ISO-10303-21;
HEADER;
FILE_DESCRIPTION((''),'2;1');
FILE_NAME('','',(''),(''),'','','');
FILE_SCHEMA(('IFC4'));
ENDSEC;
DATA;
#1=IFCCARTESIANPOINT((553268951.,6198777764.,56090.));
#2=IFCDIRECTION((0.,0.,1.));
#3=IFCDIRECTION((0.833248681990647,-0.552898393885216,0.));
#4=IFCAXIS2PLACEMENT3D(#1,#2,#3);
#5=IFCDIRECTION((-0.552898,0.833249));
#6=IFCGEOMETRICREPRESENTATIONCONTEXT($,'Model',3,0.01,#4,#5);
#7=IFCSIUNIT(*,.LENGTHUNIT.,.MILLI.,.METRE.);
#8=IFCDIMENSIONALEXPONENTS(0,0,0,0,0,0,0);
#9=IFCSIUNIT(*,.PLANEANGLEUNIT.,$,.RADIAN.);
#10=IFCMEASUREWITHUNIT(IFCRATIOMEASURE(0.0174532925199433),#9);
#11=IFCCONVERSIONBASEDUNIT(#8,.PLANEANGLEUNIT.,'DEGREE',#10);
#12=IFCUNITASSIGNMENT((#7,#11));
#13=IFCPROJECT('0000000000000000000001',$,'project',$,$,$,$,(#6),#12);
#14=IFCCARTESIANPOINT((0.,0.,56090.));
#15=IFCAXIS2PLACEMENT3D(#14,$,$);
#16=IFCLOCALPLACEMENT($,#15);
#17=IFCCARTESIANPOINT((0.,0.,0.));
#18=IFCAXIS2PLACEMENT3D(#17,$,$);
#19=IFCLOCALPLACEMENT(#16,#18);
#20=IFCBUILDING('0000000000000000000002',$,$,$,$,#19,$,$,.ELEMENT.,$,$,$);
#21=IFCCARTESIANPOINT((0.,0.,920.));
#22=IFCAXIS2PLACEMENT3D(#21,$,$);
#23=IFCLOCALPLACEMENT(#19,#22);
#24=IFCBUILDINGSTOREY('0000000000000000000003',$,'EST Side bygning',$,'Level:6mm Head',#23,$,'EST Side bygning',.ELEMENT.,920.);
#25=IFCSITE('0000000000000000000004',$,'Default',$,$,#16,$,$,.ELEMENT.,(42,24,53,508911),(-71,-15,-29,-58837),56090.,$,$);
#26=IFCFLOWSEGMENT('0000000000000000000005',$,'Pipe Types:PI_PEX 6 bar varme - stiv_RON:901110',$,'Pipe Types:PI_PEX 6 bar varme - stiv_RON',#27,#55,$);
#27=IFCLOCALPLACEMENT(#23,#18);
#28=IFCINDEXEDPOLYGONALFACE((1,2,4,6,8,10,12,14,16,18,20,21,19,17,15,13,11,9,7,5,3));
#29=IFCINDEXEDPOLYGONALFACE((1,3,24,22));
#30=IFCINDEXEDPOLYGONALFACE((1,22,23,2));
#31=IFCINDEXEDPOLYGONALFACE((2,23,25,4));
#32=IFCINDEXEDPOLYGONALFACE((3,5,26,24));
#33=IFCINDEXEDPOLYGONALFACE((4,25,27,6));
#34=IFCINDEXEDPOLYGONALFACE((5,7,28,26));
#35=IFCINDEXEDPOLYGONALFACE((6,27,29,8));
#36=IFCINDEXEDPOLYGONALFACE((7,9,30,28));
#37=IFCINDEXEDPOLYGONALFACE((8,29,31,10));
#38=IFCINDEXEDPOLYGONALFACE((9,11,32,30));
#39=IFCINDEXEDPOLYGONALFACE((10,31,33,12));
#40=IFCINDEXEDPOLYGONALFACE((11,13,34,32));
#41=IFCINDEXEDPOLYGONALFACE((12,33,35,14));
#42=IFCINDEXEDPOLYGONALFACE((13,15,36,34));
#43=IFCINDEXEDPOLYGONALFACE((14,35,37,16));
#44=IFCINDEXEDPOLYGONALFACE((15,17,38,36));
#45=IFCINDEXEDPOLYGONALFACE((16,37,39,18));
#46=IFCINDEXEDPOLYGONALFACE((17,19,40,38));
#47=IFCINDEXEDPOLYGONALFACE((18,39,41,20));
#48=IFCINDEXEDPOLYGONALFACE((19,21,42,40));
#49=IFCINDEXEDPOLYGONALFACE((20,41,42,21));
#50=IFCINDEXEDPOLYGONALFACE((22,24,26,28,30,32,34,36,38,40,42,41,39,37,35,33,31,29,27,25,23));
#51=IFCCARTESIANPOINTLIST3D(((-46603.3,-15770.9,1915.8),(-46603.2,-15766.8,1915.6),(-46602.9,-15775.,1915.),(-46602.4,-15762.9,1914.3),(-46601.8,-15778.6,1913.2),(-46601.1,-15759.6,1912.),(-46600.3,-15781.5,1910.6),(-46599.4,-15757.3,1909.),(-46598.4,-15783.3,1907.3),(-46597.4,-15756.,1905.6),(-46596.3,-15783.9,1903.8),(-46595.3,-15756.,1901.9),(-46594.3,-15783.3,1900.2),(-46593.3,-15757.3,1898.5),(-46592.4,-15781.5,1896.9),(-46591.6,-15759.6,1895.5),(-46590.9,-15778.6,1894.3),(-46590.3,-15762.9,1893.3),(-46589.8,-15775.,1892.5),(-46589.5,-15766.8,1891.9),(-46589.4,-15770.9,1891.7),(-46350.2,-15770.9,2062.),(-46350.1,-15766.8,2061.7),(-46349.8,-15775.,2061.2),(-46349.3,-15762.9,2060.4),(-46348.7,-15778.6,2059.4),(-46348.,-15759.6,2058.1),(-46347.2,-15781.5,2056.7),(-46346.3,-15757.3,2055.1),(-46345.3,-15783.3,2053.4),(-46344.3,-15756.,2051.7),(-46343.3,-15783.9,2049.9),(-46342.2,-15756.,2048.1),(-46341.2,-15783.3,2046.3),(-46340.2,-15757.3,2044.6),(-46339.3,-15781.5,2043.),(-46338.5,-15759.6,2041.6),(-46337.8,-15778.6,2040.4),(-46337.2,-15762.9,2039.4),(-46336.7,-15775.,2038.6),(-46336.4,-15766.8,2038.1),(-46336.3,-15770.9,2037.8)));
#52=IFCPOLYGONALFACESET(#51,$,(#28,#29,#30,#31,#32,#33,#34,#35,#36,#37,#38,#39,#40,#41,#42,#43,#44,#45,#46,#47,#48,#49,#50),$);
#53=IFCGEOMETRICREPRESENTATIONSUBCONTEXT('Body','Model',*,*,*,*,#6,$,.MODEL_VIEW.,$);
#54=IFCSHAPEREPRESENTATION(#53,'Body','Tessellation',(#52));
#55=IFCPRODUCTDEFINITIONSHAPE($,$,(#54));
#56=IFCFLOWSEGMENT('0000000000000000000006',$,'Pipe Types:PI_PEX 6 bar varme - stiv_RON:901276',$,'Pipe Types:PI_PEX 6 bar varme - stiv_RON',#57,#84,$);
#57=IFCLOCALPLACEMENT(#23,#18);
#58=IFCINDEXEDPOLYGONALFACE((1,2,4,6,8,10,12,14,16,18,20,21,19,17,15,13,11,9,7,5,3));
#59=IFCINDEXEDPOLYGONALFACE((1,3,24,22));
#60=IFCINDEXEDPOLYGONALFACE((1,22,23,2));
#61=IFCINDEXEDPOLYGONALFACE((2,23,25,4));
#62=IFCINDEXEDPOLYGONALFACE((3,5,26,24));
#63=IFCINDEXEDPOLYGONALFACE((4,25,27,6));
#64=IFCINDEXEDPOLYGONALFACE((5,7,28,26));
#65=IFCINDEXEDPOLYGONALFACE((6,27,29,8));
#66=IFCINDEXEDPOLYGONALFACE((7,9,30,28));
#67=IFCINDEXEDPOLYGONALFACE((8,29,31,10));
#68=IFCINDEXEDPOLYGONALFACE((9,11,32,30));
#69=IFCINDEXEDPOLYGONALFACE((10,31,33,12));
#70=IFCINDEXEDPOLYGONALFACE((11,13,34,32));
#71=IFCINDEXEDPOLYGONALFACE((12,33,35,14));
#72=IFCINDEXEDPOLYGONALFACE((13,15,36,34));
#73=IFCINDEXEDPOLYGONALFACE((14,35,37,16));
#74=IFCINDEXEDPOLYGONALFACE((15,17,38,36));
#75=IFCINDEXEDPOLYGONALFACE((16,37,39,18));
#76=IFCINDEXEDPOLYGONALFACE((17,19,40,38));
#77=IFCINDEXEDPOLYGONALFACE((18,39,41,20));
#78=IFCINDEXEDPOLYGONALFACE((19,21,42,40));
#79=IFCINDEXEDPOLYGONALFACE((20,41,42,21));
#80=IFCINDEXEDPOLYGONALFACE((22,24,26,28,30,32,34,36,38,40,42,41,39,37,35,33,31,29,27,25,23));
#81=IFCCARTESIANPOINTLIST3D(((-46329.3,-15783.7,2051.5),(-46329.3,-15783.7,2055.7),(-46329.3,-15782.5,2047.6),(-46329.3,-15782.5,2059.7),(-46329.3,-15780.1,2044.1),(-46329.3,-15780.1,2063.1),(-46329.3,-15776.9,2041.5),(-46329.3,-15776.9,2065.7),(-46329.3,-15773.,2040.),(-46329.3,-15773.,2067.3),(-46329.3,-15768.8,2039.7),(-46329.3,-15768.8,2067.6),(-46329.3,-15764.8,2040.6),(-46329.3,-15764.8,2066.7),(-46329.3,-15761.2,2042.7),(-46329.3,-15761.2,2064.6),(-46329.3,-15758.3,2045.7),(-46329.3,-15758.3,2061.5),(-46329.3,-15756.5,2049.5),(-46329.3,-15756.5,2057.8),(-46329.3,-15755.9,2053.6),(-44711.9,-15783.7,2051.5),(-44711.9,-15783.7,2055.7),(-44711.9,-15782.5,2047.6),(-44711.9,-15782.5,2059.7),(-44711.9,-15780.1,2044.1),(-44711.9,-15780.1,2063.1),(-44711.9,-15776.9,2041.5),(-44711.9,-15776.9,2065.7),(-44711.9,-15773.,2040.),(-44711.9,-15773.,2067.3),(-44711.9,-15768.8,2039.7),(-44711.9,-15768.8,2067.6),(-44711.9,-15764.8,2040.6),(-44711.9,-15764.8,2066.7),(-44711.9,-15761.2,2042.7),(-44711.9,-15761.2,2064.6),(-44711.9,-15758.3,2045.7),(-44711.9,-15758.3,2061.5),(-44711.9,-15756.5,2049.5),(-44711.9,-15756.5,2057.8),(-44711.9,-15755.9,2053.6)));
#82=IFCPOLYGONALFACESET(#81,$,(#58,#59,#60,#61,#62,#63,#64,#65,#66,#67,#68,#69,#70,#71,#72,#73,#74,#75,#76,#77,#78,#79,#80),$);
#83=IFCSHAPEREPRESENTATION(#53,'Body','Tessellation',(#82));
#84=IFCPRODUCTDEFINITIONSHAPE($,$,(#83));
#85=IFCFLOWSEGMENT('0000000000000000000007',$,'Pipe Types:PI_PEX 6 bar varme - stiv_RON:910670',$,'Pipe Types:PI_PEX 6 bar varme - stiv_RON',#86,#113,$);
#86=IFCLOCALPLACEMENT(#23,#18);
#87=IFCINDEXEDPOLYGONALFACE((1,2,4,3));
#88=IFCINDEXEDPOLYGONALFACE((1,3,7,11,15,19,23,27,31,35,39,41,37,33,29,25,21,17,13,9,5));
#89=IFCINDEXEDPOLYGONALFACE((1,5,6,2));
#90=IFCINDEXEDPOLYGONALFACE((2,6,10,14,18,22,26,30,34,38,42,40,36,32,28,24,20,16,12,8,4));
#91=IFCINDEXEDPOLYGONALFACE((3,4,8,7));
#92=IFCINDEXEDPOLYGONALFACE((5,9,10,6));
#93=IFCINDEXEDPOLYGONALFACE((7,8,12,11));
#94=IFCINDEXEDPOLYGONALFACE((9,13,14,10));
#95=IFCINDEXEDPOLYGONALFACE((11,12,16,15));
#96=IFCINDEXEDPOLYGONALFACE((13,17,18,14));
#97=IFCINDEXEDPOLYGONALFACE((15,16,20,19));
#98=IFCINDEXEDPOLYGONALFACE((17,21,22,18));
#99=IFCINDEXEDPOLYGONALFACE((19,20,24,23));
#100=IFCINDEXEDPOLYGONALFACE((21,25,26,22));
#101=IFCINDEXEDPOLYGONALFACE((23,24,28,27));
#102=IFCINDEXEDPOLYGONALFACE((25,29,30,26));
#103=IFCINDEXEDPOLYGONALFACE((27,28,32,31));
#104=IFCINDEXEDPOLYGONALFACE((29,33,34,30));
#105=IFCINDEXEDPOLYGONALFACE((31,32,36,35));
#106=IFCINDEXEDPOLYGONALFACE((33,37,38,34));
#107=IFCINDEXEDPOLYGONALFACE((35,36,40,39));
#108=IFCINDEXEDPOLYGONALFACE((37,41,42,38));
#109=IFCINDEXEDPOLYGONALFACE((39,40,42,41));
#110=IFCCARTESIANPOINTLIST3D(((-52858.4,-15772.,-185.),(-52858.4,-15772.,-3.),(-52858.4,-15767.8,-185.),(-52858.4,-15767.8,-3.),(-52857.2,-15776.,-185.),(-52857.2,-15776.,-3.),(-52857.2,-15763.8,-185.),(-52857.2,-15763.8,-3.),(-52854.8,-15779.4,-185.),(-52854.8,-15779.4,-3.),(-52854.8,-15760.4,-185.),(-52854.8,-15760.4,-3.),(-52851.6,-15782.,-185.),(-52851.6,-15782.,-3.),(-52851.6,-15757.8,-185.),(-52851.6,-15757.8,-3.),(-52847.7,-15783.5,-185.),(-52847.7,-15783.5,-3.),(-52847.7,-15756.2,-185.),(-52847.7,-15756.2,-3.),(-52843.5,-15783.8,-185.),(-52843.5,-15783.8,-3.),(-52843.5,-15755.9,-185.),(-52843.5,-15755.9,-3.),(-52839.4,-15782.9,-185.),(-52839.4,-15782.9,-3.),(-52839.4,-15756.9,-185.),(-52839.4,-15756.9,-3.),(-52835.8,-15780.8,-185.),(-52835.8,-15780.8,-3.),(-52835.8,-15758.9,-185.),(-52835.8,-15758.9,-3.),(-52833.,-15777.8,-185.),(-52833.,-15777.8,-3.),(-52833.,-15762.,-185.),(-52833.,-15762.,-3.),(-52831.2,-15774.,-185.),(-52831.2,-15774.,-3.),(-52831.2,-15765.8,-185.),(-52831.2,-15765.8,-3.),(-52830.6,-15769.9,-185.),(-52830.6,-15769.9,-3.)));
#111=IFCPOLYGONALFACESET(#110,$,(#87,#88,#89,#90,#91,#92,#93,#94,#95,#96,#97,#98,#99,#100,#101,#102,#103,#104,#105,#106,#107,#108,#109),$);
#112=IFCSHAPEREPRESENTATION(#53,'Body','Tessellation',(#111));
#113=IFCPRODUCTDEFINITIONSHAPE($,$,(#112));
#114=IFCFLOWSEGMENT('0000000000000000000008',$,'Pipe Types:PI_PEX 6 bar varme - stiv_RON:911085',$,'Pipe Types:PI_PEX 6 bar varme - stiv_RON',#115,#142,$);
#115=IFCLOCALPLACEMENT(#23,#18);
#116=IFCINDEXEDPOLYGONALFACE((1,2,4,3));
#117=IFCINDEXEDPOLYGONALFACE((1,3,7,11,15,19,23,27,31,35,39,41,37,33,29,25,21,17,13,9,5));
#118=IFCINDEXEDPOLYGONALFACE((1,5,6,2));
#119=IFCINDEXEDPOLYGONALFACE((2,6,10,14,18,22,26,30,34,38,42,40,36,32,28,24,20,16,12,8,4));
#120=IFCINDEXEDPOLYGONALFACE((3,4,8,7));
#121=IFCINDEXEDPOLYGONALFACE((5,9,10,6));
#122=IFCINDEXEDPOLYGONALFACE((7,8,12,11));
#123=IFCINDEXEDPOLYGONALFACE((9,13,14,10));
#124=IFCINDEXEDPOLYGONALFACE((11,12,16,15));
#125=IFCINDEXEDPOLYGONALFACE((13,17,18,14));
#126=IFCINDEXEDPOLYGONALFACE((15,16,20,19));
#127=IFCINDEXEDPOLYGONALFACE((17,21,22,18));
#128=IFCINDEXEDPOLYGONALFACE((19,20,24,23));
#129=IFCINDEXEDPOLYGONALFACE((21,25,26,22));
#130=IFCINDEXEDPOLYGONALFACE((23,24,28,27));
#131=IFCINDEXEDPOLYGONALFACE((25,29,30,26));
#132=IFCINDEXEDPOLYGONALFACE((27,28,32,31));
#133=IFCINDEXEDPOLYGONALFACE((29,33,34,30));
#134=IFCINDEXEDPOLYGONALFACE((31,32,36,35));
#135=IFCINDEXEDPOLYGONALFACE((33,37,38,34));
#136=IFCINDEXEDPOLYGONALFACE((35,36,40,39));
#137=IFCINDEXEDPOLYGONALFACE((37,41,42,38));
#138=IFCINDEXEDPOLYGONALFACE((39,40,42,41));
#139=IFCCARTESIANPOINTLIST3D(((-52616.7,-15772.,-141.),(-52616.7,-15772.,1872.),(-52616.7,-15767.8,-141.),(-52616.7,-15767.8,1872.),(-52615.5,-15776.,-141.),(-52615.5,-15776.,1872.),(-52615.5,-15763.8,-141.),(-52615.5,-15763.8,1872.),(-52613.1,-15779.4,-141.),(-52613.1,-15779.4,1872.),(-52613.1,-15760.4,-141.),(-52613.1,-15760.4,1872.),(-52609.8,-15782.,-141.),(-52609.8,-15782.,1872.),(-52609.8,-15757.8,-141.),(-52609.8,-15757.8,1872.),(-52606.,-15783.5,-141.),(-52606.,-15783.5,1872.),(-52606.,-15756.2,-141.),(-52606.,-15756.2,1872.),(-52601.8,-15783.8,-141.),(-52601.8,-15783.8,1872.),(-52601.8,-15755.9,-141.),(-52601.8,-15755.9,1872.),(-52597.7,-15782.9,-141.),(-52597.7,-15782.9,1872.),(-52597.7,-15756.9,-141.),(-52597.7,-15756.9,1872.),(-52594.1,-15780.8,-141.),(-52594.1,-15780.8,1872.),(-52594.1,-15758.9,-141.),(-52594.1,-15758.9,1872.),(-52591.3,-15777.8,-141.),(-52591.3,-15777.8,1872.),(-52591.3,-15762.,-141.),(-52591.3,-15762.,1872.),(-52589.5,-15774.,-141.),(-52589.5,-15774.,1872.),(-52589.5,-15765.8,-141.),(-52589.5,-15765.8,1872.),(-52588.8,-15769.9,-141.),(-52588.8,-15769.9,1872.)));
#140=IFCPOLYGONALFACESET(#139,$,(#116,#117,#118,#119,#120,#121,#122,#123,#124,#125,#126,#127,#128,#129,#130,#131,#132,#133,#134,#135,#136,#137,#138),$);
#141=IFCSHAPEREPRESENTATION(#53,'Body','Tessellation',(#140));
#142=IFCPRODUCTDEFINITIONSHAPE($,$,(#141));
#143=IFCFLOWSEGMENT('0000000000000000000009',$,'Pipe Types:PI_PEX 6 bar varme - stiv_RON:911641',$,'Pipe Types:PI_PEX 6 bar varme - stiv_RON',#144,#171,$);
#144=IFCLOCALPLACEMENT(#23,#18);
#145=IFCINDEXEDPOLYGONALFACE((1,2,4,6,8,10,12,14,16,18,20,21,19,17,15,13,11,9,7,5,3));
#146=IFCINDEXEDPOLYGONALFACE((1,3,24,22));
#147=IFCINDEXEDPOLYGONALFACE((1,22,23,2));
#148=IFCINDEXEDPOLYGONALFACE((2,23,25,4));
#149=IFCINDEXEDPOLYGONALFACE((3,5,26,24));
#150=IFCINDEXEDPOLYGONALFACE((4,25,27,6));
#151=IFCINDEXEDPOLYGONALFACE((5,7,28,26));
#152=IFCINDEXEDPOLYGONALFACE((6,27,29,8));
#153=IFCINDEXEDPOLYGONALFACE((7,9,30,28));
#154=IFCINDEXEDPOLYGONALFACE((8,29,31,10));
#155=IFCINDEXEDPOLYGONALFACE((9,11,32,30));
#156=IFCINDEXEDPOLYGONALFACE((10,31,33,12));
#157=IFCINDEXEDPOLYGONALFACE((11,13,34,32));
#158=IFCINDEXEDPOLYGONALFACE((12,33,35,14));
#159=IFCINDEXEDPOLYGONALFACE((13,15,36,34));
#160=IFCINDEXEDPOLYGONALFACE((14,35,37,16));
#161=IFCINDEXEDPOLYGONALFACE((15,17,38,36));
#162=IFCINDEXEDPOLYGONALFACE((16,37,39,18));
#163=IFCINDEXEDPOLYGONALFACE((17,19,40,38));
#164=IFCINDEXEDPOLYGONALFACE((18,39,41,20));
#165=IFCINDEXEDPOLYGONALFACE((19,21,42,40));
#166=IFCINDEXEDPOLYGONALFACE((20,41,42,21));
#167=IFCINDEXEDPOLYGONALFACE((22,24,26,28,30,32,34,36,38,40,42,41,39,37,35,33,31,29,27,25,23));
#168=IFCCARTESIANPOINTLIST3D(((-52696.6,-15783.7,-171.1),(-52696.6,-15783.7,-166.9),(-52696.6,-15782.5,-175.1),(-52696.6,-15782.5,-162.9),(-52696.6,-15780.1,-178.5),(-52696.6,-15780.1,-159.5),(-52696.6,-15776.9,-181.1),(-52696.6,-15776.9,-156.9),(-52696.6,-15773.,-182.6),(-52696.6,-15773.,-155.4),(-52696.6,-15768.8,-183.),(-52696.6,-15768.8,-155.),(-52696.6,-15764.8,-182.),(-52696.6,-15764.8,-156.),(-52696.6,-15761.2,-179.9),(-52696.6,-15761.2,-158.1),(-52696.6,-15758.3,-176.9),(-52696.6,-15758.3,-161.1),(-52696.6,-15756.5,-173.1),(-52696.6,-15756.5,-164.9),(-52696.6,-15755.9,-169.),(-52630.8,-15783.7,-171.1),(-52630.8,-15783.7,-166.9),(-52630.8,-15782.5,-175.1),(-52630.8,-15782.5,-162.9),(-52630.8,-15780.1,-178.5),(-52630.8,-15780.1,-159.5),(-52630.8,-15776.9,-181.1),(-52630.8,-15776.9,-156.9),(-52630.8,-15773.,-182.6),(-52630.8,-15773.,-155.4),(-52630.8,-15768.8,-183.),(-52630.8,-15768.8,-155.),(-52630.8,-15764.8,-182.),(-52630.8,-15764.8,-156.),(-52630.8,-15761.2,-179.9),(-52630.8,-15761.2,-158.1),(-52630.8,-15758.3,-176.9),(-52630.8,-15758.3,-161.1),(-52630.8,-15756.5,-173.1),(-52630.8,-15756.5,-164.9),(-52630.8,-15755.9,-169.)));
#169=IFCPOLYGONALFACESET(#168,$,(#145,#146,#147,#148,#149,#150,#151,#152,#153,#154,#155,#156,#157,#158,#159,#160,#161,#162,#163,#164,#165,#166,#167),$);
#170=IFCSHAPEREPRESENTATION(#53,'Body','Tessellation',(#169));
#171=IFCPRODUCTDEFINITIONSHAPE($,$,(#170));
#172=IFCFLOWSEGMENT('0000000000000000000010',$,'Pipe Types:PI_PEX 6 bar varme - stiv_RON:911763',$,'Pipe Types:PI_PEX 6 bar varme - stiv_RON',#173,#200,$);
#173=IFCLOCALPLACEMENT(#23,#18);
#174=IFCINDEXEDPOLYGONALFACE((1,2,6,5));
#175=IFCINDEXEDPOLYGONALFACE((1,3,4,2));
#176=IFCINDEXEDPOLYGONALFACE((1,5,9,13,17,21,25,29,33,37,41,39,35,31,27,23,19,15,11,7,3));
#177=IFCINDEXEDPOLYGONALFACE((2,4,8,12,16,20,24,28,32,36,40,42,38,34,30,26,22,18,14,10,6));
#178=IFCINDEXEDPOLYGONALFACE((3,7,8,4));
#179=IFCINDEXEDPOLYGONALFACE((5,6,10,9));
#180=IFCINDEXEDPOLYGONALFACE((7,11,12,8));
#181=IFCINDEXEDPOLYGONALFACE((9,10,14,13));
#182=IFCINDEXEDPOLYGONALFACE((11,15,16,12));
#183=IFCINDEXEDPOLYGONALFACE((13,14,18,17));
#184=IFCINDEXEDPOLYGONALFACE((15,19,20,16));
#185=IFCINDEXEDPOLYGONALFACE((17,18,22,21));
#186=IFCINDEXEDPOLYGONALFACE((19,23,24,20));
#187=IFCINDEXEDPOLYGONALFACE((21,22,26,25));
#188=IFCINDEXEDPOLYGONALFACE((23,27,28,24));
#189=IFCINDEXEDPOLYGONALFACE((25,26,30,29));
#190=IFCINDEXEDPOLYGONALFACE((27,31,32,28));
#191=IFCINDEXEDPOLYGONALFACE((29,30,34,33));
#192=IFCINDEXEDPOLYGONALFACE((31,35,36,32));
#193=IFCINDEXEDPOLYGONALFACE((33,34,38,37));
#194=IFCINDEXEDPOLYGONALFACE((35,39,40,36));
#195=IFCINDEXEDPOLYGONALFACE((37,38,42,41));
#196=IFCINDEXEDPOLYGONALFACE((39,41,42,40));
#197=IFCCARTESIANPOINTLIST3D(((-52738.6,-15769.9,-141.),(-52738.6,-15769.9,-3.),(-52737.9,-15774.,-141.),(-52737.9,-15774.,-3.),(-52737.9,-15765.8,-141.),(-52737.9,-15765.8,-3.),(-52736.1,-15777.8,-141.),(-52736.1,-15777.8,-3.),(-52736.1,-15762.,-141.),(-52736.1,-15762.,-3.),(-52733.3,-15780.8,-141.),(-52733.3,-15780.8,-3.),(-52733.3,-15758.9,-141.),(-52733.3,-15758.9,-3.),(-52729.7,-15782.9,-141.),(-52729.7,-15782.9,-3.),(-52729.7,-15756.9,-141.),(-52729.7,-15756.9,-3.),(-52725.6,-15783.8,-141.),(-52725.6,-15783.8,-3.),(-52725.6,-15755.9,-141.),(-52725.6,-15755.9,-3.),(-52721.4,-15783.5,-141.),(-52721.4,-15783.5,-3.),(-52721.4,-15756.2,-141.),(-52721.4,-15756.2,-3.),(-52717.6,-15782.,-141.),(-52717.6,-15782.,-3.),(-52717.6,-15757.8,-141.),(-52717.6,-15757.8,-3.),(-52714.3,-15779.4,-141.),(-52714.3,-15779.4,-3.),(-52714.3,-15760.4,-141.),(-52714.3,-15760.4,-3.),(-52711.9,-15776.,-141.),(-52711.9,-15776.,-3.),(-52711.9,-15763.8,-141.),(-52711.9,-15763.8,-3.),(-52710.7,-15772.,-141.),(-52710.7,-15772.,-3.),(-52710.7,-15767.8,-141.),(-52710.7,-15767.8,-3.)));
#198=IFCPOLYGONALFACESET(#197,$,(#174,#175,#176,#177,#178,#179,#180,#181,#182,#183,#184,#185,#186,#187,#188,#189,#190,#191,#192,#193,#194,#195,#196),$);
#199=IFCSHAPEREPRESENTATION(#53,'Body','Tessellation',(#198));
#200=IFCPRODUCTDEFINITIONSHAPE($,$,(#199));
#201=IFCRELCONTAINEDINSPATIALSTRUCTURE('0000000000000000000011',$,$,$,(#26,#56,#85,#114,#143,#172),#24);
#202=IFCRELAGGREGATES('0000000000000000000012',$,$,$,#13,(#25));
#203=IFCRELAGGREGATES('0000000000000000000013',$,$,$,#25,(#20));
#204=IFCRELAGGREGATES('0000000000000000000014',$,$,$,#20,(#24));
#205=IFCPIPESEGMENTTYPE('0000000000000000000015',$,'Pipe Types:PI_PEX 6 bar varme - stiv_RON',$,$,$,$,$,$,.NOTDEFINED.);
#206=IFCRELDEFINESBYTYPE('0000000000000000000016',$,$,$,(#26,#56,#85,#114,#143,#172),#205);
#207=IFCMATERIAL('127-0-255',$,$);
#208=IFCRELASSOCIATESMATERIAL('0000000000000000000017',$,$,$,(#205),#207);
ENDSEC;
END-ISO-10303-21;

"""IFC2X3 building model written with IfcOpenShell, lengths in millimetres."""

from ifc_helpers import new_model, entity, si_unit, converted_unit, direction, frame, frame_2d, origin, origin_2d_with_axis, place, context, subcontext, project, spatial, circle, extrude, material, type_object, element, save


model = new_model("IFC2X3")

# Units and contexts
model_context = context("Model", 3, precision=0.01, world=frame((553268951.0, 6198777764.0, 56090.0), z_axis=(0.0, 0.0, 1.0), x_axis=(0.833248681990647, -0.552898393885216, 0.0)), true_north=direction((-0.552898, 0.833249)))
body_context = subcontext(model_context, "Body", "Model", "MODEL_VIEW")
ifc_project = project(units=[si_unit("LENGTHUNIT", "METRE", prefix="MILLI"), converted_unit("PLANEANGLEUNIT", "DEGREE", entity("IfcRatioMeasure", 0.0174532925199433), si_unit("PLANEANGLEUNIT", "RADIAN"), dimensions=[0, 0, 0, 0, 0, 0, 0])], contexts=[model_context])

# Site, building, storey
site_placement = place(None, frame((0.0, 0.0, 56090.0)))
site = spatial("IfcSite", under=ifc_project, at=site_placement, Name="Default", CompositionType="ELEMENT", RefLatitude=(42, 24, 53, 508911), RefLongitude=(-71, -15, -29, -58837), RefElevation=56090.0)
building_placement = place(site_placement, origin())
building = spatial("IfcBuilding", under=site, at=building_placement, CompositionType="ELEMENT")
storey_placement = place(building_placement, frame((0.0, 0.0, 920.0)))
storey = spatial("IfcBuildingStorey", under=building, at=storey_placement, Name="EST Side bygning", ObjectType="Level:6mm Head", LongName="EST Side bygning", CompositionType="ELEMENT", Elevation=920.0)

# Flow segments
ifc_material_1 = material(Name="127-0-255")
pipe_segment_type_1 = type_object("IfcPipeSegmentType", Name="Pipe Types:PI_PEX 6 bar varme - stiv_RON", PredefinedType="NOTDEFINED", material=ifc_material_1)
flow_segment_1_placement = place(storey_placement, origin())
element("IfcFlowSegment", 1, at=flow_segment_1_placement, inside=storey, type_object=pipe_segment_type_1, Name="Pipe Types:PI_PEX 6 bar varme - stiv_RON:901110", ObjectType="Pipe Types:PI_PEX 6 bar varme - stiv_RON", context=body_context, shape_type="SweptSolid", body=[
    extrude(circle(Radius=14.0, at=frame_2d((0.0, 0.0), x_axis=(1.0, 0.0))), frame((-46596.3, -15769.9, 1903.8), z_axis=(0.866025, 0.0, 0.5), x_axis=(0.0, -1.0, 0.0)), (0.0, 0.0, 1.0), 292.2),
])
flow_segment_2_placement = place(storey_placement, origin())
element("IfcFlowSegment", 2, at=flow_segment_2_placement, inside=storey, type_object=pipe_segment_type_1, Name="Pipe Types:PI_PEX 6 bar varme - stiv_RON:901276", ObjectType="Pipe Types:PI_PEX 6 bar varme - stiv_RON", context=body_context, shape_type="SweptSolid", body=[
    extrude(circle(Radius=14.0, at=origin_2d_with_axis()), frame((-46329.3, -15769.9, 2053.6), z_axis=(1.0, 0.0, 0.0), x_axis=(0.0, 1.0, 0.0)), (0.0, 0.0, 1.0), 1617.4),
])
flow_segment_3_placement = place(storey_placement, origin())
element("IfcFlowSegment", 3, at=flow_segment_3_placement, inside=storey, type_object=pipe_segment_type_1, Name="Pipe Types:PI_PEX 6 bar varme - stiv_RON:910670", ObjectType="Pipe Types:PI_PEX 6 bar varme - stiv_RON", context=body_context, shape_type="SweptSolid", body=[
    extrude(circle(Radius=14.0, at=origin_2d_with_axis()), frame((-52844.6, -15769.9, -185.0)), (0.0, 0.0, 1.0), 182.0),
])
flow_segment_4_placement = place(storey_placement, origin())
element("IfcFlowSegment", 4, at=flow_segment_4_placement, inside=storey, type_object=pipe_segment_type_1, Name="Pipe Types:PI_PEX 6 bar varme - stiv_RON:911085", ObjectType="Pipe Types:PI_PEX 6 bar varme - stiv_RON", context=body_context, shape_type="SweptSolid", body=[
    extrude(circle(Radius=14.0, at=origin_2d_with_axis()), frame((-52602.8, -15769.9, -141.0)), (0.0, 0.0, 1.0), 2013.0),
])
flow_segment_5_placement = place(storey_placement, origin())
element("IfcFlowSegment", 5, at=flow_segment_5_placement, inside=storey, type_object=pipe_segment_type_1, Name="Pipe Types:PI_PEX 6 bar varme - stiv_RON:911641", ObjectType="Pipe Types:PI_PEX 6 bar varme - stiv_RON", context=body_context, shape_type="SweptSolid", body=[
    extrude(circle(Radius=14.0, at=frame_2d((0.0, 0.0), x_axis=(1.0, 0.0))), frame((-52696.6, -15769.9, -169.0), z_axis=(1.0, 0.0, 0.0), x_axis=(0.0, 1.0, 0.0)), (0.0, 0.0, 1.0), 65.7),
])
flow_segment_6_placement = place(storey_placement, origin())
element("IfcFlowSegment", 6, at=flow_segment_6_placement, inside=storey, type_object=pipe_segment_type_1, Name="Pipe Types:PI_PEX 6 bar varme - stiv_RON:911763", ObjectType="Pipe Types:PI_PEX 6 bar varme - stiv_RON", context=body_context, shape_type="SweptSolid", body=[
    extrude(circle(Radius=14.0, at=origin_2d_with_axis()), frame((-52724.6, -15769.9, -141.0), z_axis=(0.0, 0.0, 1.0), x_axis=(-1.0, 0.0, 0.0)), (0.0, 0.0, 1.0), 138.0),
])

save(model, "model.ifc")
